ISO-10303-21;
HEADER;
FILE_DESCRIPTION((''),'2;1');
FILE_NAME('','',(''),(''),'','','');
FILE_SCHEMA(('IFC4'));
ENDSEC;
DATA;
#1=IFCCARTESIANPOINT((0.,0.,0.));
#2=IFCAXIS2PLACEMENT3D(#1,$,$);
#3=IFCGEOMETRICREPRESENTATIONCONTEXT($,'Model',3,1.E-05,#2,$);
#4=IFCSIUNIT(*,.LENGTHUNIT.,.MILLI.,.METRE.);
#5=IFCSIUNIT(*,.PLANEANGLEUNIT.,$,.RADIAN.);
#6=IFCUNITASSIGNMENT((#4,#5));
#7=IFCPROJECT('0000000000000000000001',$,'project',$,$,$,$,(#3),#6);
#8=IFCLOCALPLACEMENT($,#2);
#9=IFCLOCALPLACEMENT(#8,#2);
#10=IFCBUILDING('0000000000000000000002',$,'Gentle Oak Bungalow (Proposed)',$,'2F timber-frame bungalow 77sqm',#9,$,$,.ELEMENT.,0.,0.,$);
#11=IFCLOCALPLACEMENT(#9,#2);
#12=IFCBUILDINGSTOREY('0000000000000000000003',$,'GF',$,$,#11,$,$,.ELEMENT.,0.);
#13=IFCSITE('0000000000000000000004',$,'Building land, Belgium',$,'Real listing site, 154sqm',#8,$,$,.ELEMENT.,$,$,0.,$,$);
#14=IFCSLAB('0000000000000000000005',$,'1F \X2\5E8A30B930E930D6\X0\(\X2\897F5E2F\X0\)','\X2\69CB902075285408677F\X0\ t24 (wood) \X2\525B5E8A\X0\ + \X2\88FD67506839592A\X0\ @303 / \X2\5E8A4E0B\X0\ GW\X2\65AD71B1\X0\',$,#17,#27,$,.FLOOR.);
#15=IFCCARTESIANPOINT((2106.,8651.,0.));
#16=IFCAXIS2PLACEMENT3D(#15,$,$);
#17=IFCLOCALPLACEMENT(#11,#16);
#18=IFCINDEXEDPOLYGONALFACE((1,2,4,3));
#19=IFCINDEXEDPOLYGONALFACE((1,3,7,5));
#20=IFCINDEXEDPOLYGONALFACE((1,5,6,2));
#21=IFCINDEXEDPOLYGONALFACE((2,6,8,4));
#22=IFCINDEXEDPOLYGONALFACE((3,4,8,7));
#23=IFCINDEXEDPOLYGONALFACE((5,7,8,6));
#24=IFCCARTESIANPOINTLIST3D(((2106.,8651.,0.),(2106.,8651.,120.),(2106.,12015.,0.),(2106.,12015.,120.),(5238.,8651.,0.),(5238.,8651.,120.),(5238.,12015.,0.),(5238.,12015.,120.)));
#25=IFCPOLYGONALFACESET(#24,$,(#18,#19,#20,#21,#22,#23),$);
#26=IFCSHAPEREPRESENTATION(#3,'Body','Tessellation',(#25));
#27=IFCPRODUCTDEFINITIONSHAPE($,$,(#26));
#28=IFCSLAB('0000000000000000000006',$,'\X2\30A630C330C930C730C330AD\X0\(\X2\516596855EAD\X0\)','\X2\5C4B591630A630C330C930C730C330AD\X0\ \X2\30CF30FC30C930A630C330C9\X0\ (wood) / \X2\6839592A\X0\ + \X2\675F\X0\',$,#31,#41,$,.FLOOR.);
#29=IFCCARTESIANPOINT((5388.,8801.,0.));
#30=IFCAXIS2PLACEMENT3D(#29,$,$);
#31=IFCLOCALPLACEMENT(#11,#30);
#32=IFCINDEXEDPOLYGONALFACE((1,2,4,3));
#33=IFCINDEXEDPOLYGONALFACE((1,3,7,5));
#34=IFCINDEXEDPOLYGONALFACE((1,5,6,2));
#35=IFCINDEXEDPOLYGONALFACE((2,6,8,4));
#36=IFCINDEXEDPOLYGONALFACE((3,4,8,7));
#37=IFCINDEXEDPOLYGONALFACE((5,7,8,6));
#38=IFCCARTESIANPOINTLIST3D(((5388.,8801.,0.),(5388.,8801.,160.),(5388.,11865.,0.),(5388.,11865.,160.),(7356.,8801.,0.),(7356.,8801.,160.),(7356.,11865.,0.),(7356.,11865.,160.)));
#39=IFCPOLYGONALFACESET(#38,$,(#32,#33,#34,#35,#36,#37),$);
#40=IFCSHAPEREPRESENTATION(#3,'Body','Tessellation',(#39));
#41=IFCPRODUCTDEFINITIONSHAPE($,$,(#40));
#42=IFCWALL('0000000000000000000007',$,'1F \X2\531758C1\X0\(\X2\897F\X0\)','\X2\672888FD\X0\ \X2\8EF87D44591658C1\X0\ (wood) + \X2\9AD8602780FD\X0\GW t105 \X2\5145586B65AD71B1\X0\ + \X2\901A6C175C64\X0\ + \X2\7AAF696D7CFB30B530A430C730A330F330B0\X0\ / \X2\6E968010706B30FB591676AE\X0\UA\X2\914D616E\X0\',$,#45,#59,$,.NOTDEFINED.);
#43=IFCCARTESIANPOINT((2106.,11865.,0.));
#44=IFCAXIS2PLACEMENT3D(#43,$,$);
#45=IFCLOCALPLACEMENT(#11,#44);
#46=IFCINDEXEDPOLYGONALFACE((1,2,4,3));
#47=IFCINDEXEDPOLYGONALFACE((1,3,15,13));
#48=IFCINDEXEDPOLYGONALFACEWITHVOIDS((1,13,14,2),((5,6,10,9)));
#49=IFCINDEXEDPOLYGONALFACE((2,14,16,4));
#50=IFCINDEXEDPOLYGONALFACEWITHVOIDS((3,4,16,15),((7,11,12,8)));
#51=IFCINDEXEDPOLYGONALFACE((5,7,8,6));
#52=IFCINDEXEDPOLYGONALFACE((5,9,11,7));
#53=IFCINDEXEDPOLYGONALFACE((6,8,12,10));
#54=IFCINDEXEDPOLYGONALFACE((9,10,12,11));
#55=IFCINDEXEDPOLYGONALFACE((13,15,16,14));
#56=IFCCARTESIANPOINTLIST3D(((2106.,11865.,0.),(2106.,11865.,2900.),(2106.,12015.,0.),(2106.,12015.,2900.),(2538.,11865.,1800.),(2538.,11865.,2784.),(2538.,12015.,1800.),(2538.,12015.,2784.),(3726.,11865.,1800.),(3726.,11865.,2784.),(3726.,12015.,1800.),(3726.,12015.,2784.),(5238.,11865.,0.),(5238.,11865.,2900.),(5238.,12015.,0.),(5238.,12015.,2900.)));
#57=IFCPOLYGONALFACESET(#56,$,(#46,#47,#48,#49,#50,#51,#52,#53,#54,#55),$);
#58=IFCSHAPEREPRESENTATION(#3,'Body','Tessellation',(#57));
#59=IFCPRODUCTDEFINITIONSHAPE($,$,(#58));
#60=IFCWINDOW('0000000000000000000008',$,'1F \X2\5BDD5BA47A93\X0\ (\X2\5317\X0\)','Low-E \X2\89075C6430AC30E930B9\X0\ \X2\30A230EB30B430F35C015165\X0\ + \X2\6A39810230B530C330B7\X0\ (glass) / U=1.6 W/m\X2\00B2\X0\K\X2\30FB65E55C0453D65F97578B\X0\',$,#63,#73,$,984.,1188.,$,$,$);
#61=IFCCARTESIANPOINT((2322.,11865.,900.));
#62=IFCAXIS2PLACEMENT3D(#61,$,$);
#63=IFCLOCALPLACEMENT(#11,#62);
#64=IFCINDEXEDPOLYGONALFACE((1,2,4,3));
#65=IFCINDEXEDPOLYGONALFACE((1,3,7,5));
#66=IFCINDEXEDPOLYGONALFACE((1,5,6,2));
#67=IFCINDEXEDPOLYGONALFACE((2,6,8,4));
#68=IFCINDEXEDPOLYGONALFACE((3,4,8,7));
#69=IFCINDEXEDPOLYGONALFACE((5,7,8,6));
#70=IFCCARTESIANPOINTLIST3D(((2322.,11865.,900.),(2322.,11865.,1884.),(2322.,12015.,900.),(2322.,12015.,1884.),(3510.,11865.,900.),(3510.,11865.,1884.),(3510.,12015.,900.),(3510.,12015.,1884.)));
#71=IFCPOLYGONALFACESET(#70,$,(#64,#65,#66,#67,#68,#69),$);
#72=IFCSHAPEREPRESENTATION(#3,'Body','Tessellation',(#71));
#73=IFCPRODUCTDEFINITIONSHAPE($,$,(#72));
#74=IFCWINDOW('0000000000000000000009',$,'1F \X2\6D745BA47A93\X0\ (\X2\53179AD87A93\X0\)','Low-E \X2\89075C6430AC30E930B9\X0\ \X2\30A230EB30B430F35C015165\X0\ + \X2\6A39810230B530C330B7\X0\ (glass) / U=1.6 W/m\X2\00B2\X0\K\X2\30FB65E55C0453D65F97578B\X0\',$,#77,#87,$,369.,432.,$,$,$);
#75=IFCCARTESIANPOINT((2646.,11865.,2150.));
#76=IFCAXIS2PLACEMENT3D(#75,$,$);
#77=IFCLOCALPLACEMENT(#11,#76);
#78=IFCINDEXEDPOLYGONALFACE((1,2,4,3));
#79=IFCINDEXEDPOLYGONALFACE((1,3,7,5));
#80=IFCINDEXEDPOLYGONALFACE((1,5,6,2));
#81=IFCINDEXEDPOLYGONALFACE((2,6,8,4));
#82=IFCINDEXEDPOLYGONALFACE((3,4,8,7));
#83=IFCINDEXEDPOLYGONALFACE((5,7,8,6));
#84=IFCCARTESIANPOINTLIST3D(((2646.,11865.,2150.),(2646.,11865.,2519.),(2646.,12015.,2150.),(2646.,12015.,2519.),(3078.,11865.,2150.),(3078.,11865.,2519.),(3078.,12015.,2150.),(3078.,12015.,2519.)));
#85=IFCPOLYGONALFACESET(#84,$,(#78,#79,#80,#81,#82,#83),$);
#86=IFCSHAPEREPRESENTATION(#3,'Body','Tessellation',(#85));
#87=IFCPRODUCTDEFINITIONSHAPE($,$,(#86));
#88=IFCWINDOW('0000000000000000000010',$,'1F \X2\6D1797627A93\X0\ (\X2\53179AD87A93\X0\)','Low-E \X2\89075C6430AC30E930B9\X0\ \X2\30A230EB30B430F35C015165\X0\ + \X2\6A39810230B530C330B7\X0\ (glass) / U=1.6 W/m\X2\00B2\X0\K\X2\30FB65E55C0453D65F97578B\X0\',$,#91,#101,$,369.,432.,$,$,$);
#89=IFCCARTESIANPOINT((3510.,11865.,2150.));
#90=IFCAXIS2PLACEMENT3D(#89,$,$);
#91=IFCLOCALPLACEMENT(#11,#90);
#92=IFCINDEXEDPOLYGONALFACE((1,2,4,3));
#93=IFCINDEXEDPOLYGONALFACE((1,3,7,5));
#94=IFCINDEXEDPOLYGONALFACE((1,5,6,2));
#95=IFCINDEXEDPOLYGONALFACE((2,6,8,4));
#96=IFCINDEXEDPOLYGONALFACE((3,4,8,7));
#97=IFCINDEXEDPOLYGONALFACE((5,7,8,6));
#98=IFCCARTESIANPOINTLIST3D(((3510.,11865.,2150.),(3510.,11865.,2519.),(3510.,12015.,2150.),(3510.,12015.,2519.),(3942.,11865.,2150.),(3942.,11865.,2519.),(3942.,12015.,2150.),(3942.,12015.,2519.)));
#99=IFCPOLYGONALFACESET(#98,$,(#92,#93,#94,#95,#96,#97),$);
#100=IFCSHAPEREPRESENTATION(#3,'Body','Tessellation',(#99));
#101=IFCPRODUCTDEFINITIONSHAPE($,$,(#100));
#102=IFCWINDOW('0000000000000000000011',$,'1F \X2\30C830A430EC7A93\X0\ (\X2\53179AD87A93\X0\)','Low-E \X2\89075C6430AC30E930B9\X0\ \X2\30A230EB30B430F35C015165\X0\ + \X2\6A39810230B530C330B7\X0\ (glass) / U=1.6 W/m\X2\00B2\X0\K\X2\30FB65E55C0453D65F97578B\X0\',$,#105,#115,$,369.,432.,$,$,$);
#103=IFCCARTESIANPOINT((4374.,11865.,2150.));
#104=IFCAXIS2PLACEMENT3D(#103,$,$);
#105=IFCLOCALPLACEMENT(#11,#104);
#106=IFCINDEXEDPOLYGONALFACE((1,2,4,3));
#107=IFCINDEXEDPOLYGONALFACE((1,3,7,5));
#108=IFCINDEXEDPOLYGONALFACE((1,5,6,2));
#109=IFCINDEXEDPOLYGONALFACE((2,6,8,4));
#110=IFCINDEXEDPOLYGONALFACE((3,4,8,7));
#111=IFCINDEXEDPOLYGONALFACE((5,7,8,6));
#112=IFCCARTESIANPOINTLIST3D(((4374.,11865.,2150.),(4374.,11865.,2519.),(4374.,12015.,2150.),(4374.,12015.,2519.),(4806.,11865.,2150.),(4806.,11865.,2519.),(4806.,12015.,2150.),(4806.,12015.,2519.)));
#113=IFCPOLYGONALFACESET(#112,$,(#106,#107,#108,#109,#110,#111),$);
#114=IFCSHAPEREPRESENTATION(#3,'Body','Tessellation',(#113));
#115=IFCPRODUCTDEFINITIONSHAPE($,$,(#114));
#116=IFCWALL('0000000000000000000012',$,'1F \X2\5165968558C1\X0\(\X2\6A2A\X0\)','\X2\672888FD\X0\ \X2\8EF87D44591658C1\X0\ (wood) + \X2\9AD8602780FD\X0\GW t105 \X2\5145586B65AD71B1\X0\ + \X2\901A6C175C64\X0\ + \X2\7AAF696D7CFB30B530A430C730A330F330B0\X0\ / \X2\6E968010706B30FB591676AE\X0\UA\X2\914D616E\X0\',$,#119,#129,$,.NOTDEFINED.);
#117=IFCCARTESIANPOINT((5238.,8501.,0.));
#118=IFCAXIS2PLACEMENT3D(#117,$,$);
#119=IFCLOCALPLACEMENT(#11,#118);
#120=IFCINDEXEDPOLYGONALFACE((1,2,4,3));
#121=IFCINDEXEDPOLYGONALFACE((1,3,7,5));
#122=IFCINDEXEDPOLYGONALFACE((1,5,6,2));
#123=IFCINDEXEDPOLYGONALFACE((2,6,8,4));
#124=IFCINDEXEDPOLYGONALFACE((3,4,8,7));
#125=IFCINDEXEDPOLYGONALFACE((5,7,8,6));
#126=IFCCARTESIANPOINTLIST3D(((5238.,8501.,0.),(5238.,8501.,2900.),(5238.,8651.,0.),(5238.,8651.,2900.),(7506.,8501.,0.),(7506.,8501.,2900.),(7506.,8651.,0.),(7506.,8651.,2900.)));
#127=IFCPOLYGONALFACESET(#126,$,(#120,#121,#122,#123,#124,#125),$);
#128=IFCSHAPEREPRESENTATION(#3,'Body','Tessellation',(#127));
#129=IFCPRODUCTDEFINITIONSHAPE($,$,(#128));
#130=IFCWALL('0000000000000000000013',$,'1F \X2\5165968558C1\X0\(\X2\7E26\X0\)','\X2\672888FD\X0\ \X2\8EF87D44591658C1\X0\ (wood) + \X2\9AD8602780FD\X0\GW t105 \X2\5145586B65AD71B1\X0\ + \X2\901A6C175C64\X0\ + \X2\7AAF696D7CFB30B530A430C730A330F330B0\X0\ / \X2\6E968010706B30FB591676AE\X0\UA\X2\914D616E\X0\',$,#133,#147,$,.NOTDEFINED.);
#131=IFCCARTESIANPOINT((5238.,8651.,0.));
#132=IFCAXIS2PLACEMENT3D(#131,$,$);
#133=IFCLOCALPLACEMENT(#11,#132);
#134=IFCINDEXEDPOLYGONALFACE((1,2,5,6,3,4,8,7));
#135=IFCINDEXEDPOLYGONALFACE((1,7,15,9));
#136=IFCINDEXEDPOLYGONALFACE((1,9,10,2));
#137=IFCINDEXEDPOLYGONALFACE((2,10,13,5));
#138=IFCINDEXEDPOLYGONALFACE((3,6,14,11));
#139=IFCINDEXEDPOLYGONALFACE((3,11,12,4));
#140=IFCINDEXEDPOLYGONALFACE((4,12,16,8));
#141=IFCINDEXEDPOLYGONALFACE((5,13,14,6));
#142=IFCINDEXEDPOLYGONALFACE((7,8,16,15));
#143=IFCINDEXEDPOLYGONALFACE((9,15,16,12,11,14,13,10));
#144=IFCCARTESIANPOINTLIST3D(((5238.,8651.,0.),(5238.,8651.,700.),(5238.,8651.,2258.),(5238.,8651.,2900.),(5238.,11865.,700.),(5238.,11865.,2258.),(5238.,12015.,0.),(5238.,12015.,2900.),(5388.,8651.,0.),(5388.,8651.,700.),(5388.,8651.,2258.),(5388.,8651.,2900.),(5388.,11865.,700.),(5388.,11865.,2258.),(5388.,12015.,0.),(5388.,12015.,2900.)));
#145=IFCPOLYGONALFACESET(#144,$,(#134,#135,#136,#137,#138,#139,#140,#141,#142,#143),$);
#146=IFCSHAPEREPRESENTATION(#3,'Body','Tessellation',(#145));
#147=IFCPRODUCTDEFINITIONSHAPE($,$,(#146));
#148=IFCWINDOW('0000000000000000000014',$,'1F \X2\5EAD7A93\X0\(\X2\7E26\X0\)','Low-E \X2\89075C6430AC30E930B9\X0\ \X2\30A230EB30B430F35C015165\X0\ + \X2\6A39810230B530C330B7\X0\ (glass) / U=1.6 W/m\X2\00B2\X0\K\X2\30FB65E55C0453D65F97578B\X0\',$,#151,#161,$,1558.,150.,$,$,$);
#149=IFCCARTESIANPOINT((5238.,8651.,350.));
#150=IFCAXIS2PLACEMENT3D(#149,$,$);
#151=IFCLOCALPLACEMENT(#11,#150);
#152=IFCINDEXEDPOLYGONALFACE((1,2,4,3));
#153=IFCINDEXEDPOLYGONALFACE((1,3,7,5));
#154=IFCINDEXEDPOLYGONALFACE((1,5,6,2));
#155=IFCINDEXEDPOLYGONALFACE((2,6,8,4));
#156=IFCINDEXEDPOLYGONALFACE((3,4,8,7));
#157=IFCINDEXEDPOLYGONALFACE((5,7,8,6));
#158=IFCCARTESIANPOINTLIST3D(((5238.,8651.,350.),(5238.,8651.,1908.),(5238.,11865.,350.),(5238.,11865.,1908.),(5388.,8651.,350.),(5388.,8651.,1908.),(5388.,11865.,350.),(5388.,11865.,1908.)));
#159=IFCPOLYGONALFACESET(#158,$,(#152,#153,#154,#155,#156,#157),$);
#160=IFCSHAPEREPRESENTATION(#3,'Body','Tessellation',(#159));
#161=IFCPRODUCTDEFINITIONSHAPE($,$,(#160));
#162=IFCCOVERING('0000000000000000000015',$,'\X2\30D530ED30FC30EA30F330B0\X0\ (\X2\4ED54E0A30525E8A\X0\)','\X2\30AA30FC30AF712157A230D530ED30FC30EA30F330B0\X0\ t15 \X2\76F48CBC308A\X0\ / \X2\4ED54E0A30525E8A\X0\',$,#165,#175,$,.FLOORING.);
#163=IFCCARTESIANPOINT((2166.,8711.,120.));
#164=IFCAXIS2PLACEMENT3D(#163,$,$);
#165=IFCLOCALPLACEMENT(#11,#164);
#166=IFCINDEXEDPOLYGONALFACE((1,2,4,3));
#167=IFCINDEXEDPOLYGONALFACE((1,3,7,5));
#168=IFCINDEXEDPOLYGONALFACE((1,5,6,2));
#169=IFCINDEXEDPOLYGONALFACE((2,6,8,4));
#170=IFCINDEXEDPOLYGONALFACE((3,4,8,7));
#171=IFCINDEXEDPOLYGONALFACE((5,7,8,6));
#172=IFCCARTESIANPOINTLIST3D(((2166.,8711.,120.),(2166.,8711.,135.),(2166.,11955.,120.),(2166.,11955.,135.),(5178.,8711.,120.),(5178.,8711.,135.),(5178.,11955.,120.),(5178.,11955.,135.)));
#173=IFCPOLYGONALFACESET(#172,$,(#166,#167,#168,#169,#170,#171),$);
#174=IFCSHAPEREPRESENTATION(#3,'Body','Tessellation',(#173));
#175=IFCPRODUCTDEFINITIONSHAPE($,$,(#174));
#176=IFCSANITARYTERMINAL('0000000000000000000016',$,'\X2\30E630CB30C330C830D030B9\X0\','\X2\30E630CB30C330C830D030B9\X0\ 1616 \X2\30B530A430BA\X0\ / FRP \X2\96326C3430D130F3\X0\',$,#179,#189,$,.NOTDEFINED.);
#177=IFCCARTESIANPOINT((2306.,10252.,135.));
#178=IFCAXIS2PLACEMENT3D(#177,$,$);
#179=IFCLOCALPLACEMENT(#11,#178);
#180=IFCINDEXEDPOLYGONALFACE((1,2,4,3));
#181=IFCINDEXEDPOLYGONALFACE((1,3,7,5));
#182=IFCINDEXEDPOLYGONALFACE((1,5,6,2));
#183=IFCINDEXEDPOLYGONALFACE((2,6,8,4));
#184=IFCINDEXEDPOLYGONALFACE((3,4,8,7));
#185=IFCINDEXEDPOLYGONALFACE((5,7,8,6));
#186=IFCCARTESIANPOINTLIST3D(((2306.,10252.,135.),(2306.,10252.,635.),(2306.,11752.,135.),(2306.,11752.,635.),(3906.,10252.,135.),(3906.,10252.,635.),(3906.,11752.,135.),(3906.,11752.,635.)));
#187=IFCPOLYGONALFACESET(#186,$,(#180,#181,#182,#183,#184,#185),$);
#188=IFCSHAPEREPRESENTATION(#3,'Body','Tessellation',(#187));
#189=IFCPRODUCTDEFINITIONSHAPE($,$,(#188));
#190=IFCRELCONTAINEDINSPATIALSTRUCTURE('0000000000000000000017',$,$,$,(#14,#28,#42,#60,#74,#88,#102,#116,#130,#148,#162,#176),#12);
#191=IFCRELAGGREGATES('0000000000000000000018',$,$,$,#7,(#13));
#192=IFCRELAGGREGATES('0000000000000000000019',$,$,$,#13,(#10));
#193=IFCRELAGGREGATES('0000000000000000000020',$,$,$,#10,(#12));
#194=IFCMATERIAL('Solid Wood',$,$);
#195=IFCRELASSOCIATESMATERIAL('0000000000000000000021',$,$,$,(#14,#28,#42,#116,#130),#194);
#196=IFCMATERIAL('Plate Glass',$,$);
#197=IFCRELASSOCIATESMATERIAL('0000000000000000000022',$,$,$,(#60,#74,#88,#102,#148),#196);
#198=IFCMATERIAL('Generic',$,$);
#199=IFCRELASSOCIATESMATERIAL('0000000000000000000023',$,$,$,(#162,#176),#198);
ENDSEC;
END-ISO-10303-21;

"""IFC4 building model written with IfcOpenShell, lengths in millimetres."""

from ifc_helpers import new_model, si_unit, frame, frame_2d, origin, place, context, project, spatial, rectangle, extrude, material, element, fill, save


model = new_model("IFC4")

# Units and contexts
model_context = context("Model", 3, precision=1e-05, world=origin())
ifc_project = project(units=[si_unit("LENGTHUNIT", "METRE", prefix="MILLI"), si_unit("PLANEANGLEUNIT", "RADIAN")], contexts=[model_context])

# Site, building, storey
site_placement = place(None, origin())
site = spatial("IfcSite", under=ifc_project, at=site_placement, Name="Building land, Belgium", ObjectType="Real listing site, 154sqm", CompositionType="ELEMENT", RefElevation=0.0)
building_placement = place(site_placement, origin())
building = spatial("IfcBuilding", under=site, at=building_placement, Name="Gentle Oak Bungalow (Proposed)", ObjectType="2F timber-frame bungalow 77sqm", CompositionType="ELEMENT", ElevationOfRefHeight=0.0, ElevationOfTerrain=0.0)
storey_placement = place(building_placement, origin())
storey = spatial("IfcBuildingStorey", under=building, at=storey_placement, Name="GF", CompositionType="ELEMENT", Elevation=0.0)

# Slabs
ifc_material_1 = material(Name="Solid Wood")
slab_1_placement = place(storey_placement, frame((2106.0, 8651.0, 0.0)))
element("IfcSlab", 1, at=slab_1_placement, inside=storey, material=ifc_material_1, Name="1F 床スラブ(西帯)", Description="構造用合板 t24 (wood) 剛床 + 製材根太 @303 / 床下 GW断熱", PredefinedType="FLOOR", context=model_context, shape_type="SweptSolid", body=[
    extrude(rectangle(XDim=3132.0, YDim=3364.0, at=frame_2d((1566.0, 1682.0))), frame((2106.0, 8651.0, 0.0)), (0.0, 0.0, 1.0), 120.0),
])
slab_2_placement = place(storey_placement, frame((5388.0, 8801.0, 0.0)))
element("IfcSlab", 2, at=slab_2_placement, inside=storey, material=ifc_material_1, Name="ウッドデッキ(入隅庭)", Description="屋外ウッドデッキ ハードウッド (wood) / 根太 + 束", PredefinedType="FLOOR", context=model_context, shape_type="SweptSolid", body=[
    extrude(rectangle(XDim=1968.0, YDim=3064.0, at=frame_2d((984.0, 1532.0))), frame((5388.0, 8801.0, 0.0)), (0.0, 0.0, 1.0), 160.0),
])

# Wall, openings, windows
wall_1_placement = place(storey_placement, frame((2106.0, 11865.0, 0.0)))
wall_1 = element("IfcWall", 3, at=wall_1_placement, inside=storey, material=ifc_material_1, Name="1F 北壁(西)", Description="木製 軸組外壁 (wood) + 高性能GW t105 充填断熱 + 通気層 + 窯業系サイディング / 準耐火・外皮UA配慮", PredefinedType="NOTDEFINED", context=model_context, shape_type="SweptSolid", body=[
    extrude(rectangle(XDim=3132.0, YDim=150.0, at=frame_2d((1566.0, 75.0))), frame((2106.0, 11865.0, 0.0)), (0.0, 0.0, 1.0), 2900.0),
])
opening_1_placement = place(storey_placement, frame((2322.0, 11865.0, 900.0)))
opening_1 = element("IfcOpeningElement", 4, at=opening_1_placement, cuts=wall_1, PredefinedType="NOTDEFINED", context=model_context, shape_type="SweptSolid", body=[
    extrude(rectangle(XDim=1188.0, YDim=150.0, at=frame_2d((594.0, 75.0))), frame((2322.0, 11865.0, 900.0)), (0.0, 0.0, 1.0), 984.0),
])
opening_2_placement = place(storey_placement, frame((2646.0, 11865.0, 2150.0)))
opening_2 = element("IfcOpeningElement", 5, at=opening_2_placement, cuts=wall_1, PredefinedType="NOTDEFINED", context=model_context, shape_type="SweptSolid", body=[
    extrude(rectangle(XDim=432.0, YDim=150.0, at=frame_2d((216.0, 75.0))), frame((2646.0, 11865.0, 2150.0)), (0.0, 0.0, 1.0), 369.0),
])
opening_3_placement = place(storey_placement, frame((3510.0, 11865.0, 2150.0)))
opening_3 = element("IfcOpeningElement", 6, at=opening_3_placement, cuts=wall_1, PredefinedType="NOTDEFINED", context=model_context, shape_type="SweptSolid", body=[
    extrude(rectangle(XDim=432.0, YDim=150.0, at=frame_2d((216.0, 75.0))), frame((3510.0, 11865.0, 2150.0)), (0.0, 0.0, 1.0), 369.0),
])
opening_4_placement = place(storey_placement, frame((4374.0, 11865.0, 2150.0)))
opening_4 = element("IfcOpeningElement", 7, at=opening_4_placement, cuts=wall_1, PredefinedType="NOTDEFINED", context=model_context, shape_type="SweptSolid", body=[
    extrude(rectangle(XDim=432.0, YDim=150.0, at=frame_2d((216.0, 75.0))), frame((4374.0, 11865.0, 2150.0)), (0.0, 0.0, 1.0), 369.0),
])
ifc_material_2 = material(Name="Plate Glass")
window_1_placement = place(storey_placement, frame((2322.0, 11865.0, 900.0)))
window_1 = element("IfcWindow", 8, at=window_1_placement, inside=storey, material=ifc_material_2, Name="1F 寝室窓 (北)", Description="Low-E 複層ガラス アルゴン封入 + 樹脂サッシ (glass) / U=1.6 W/m²K・日射取得型", OverallHeight=984.0, OverallWidth=1188.0, context=model_context, shape_type="SweptSolid", body=[
    extrude(rectangle(XDim=1188.0, YDim=150.0, at=frame_2d((594.0, 75.0))), frame((2322.0, 11865.0, 900.0)), (0.0, 0.0, 1.0), 984.0),
])
fill(opening_1, window_1)
window_2_placement = place(storey_placement, frame((2646.0, 11865.0, 2150.0)))
window_2 = element("IfcWindow", 9, at=window_2_placement, inside=storey, material=ifc_material_2, Name="1F 浴室窓 (北高窓)", Description="Low-E 複層ガラス アルゴン封入 + 樹脂サッシ (glass) / U=1.6 W/m²K・日射取得型", OverallHeight=369.0, OverallWidth=432.0, context=model_context, shape_type="SweptSolid", body=[
    extrude(rectangle(XDim=432.0, YDim=150.0, at=frame_2d((216.0, 75.0))), frame((2646.0, 11865.0, 2150.0)), (0.0, 0.0, 1.0), 369.0),
])
fill(opening_2, window_2)
window_3_placement = place(storey_placement, frame((3510.0, 11865.0, 2150.0)))
window_3 = element("IfcWindow", 10, at=window_3_placement, inside=storey, material=ifc_material_2, Name="1F 洗面窓 (北高窓)", Description="Low-E 複層ガラス アルゴン封入 + 樹脂サッシ (glass) / U=1.6 W/m²K・日射取得型", OverallHeight=369.0, OverallWidth=432.0, context=model_context, shape_type="SweptSolid", body=[
    extrude(rectangle(XDim=432.0, YDim=150.0, at=frame_2d((216.0, 75.0))), frame((3510.0, 11865.0, 2150.0)), (0.0, 0.0, 1.0), 369.0),
])
fill(opening_3, window_3)
window_4_placement = place(storey_placement, frame((4374.0, 11865.0, 2150.0)))
window_4 = element("IfcWindow", 11, at=window_4_placement, inside=storey, material=ifc_material_2, Name="1F トイレ窓 (北高窓)", Description="Low-E 複層ガラス アルゴン封入 + 樹脂サッシ (glass) / U=1.6 W/m²K・日射取得型", OverallHeight=369.0, OverallWidth=432.0, context=model_context, shape_type="SweptSolid", body=[
    extrude(rectangle(XDim=432.0, YDim=150.0, at=frame_2d((216.0, 75.0))), frame((4374.0, 11865.0, 2150.0)), (0.0, 0.0, 1.0), 369.0),
])
fill(opening_4, window_4)

# Wall
wall_2_placement = place(storey_placement, frame((5238.0, 8501.0, 0.0)))
element("IfcWall", 12, at=wall_2_placement, inside=storey, material=ifc_material_1, Name="1F 入隅壁(横)", Description="木製 軸組外壁 (wood) + 高性能GW t105 充填断熱 + 通気層 + 窯業系サイディング / 準耐火・外皮UA配慮", PredefinedType="NOTDEFINED", context=model_context, shape_type="SweptSolid", body=[
    extrude(rectangle(XDim=2268.0, YDim=150.0, at=frame_2d((1134.0, 75.0))), frame((5238.0, 8501.0, 0.0)), (0.0, 0.0, 1.0), 2900.0),
])

# Wall, opening, window
wall_3_placement = place(storey_placement, frame((5238.0, 8651.0, 0.0)))
wall_3 = element("IfcWall", 13, at=wall_3_placement, inside=storey, material=ifc_material_1, Name="1F 入隅壁(縦)", Description="木製 軸組外壁 (wood) + 高性能GW t105 充填断熱 + 通気層 + 窯業系サイディング / 準耐火・外皮UA配慮", PredefinedType="NOTDEFINED", context=model_context, shape_type="SweptSolid", body=[
    extrude(rectangle(XDim=150.0, YDim=3364.0, at=frame_2d((75.0, 1682.0))), frame((5238.0, 8651.0, 0.0)), (0.0, 0.0, 1.0), 2900.0),
])
opening_5_placement = place(storey_placement, frame((5238.0, 8651.0, 350.0)))
opening_5 = element("IfcOpeningElement", 14, at=opening_5_placement, cuts=wall_3, PredefinedType="NOTDEFINED", context=model_context, shape_type="SweptSolid", body=[
    extrude(rectangle(XDim=150.0, YDim=3214.0, at=frame_2d((75.0, 1607.0))), frame((5238.0, 8651.0, 350.0)), (0.0, 0.0, 1.0), 1558.0),
])
window_5_placement = place(storey_placement, frame((5238.0, 8651.0, 350.0)))
window_5 = element("IfcWindow", 15, at=window_5_placement, inside=storey, material=ifc_material_2, Name="1F 庭窓(縦)", Description="Low-E 複層ガラス アルゴン封入 + 樹脂サッシ (glass) / U=1.6 W/m²K・日射取得型", OverallHeight=1558.0, OverallWidth=150.0, context=model_context, shape_type="SweptSolid", body=[
    extrude(rectangle(XDim=150.0, YDim=3214.0, at=frame_2d((75.0, 1607.0))), frame((5238.0, 8651.0, 350.0)), (0.0, 0.0, 1.0), 1558.0),
])
fill(opening_5, window_5)

# Covering
ifc_material_3 = material(Name="Generic")
covering_placement = place(storey_placement, frame((2166.0, 8711.0, 120.0)))
element("IfcCovering", 16, at=covering_placement, inside=storey, material=ifc_material_3, Name="フローリング (仕上げ床)", Description="オーク無垢フローリング t15 直貼り / 仕上げ床", PredefinedType="FLOORING", context=model_context, shape_type="SweptSolid", body=[
    extrude(rectangle(XDim=3012.0, YDim=3244.0, at=frame_2d((1506.0, 1622.0))), frame((2166.0, 8711.0, 120.0)), (0.0, 0.0, 1.0), 15.0),
])

# Sanitary terminal
sanitary_terminal_1_placement = place(storey_placement, frame((2306.0, 10252.0, 135.0)))
element("IfcSanitaryTerminal", 17, at=sanitary_terminal_1_placement, inside=storey, material=ifc_material_3, Name="ユニットバス", Description="ユニットバス 1616 サイズ / FRP 防水パン", PredefinedType="NOTDEFINED", context=model_context, shape_type="SweptSolid", body=[
    extrude(rectangle(XDim=1600.0, YDim=1500.0, at=frame_2d((800.0, 750.0))), frame((2306.0, 10252.0, 135.0)), (0.0, 0.0, 1.0), 500.0),
])

save(model, "model.ifc")
